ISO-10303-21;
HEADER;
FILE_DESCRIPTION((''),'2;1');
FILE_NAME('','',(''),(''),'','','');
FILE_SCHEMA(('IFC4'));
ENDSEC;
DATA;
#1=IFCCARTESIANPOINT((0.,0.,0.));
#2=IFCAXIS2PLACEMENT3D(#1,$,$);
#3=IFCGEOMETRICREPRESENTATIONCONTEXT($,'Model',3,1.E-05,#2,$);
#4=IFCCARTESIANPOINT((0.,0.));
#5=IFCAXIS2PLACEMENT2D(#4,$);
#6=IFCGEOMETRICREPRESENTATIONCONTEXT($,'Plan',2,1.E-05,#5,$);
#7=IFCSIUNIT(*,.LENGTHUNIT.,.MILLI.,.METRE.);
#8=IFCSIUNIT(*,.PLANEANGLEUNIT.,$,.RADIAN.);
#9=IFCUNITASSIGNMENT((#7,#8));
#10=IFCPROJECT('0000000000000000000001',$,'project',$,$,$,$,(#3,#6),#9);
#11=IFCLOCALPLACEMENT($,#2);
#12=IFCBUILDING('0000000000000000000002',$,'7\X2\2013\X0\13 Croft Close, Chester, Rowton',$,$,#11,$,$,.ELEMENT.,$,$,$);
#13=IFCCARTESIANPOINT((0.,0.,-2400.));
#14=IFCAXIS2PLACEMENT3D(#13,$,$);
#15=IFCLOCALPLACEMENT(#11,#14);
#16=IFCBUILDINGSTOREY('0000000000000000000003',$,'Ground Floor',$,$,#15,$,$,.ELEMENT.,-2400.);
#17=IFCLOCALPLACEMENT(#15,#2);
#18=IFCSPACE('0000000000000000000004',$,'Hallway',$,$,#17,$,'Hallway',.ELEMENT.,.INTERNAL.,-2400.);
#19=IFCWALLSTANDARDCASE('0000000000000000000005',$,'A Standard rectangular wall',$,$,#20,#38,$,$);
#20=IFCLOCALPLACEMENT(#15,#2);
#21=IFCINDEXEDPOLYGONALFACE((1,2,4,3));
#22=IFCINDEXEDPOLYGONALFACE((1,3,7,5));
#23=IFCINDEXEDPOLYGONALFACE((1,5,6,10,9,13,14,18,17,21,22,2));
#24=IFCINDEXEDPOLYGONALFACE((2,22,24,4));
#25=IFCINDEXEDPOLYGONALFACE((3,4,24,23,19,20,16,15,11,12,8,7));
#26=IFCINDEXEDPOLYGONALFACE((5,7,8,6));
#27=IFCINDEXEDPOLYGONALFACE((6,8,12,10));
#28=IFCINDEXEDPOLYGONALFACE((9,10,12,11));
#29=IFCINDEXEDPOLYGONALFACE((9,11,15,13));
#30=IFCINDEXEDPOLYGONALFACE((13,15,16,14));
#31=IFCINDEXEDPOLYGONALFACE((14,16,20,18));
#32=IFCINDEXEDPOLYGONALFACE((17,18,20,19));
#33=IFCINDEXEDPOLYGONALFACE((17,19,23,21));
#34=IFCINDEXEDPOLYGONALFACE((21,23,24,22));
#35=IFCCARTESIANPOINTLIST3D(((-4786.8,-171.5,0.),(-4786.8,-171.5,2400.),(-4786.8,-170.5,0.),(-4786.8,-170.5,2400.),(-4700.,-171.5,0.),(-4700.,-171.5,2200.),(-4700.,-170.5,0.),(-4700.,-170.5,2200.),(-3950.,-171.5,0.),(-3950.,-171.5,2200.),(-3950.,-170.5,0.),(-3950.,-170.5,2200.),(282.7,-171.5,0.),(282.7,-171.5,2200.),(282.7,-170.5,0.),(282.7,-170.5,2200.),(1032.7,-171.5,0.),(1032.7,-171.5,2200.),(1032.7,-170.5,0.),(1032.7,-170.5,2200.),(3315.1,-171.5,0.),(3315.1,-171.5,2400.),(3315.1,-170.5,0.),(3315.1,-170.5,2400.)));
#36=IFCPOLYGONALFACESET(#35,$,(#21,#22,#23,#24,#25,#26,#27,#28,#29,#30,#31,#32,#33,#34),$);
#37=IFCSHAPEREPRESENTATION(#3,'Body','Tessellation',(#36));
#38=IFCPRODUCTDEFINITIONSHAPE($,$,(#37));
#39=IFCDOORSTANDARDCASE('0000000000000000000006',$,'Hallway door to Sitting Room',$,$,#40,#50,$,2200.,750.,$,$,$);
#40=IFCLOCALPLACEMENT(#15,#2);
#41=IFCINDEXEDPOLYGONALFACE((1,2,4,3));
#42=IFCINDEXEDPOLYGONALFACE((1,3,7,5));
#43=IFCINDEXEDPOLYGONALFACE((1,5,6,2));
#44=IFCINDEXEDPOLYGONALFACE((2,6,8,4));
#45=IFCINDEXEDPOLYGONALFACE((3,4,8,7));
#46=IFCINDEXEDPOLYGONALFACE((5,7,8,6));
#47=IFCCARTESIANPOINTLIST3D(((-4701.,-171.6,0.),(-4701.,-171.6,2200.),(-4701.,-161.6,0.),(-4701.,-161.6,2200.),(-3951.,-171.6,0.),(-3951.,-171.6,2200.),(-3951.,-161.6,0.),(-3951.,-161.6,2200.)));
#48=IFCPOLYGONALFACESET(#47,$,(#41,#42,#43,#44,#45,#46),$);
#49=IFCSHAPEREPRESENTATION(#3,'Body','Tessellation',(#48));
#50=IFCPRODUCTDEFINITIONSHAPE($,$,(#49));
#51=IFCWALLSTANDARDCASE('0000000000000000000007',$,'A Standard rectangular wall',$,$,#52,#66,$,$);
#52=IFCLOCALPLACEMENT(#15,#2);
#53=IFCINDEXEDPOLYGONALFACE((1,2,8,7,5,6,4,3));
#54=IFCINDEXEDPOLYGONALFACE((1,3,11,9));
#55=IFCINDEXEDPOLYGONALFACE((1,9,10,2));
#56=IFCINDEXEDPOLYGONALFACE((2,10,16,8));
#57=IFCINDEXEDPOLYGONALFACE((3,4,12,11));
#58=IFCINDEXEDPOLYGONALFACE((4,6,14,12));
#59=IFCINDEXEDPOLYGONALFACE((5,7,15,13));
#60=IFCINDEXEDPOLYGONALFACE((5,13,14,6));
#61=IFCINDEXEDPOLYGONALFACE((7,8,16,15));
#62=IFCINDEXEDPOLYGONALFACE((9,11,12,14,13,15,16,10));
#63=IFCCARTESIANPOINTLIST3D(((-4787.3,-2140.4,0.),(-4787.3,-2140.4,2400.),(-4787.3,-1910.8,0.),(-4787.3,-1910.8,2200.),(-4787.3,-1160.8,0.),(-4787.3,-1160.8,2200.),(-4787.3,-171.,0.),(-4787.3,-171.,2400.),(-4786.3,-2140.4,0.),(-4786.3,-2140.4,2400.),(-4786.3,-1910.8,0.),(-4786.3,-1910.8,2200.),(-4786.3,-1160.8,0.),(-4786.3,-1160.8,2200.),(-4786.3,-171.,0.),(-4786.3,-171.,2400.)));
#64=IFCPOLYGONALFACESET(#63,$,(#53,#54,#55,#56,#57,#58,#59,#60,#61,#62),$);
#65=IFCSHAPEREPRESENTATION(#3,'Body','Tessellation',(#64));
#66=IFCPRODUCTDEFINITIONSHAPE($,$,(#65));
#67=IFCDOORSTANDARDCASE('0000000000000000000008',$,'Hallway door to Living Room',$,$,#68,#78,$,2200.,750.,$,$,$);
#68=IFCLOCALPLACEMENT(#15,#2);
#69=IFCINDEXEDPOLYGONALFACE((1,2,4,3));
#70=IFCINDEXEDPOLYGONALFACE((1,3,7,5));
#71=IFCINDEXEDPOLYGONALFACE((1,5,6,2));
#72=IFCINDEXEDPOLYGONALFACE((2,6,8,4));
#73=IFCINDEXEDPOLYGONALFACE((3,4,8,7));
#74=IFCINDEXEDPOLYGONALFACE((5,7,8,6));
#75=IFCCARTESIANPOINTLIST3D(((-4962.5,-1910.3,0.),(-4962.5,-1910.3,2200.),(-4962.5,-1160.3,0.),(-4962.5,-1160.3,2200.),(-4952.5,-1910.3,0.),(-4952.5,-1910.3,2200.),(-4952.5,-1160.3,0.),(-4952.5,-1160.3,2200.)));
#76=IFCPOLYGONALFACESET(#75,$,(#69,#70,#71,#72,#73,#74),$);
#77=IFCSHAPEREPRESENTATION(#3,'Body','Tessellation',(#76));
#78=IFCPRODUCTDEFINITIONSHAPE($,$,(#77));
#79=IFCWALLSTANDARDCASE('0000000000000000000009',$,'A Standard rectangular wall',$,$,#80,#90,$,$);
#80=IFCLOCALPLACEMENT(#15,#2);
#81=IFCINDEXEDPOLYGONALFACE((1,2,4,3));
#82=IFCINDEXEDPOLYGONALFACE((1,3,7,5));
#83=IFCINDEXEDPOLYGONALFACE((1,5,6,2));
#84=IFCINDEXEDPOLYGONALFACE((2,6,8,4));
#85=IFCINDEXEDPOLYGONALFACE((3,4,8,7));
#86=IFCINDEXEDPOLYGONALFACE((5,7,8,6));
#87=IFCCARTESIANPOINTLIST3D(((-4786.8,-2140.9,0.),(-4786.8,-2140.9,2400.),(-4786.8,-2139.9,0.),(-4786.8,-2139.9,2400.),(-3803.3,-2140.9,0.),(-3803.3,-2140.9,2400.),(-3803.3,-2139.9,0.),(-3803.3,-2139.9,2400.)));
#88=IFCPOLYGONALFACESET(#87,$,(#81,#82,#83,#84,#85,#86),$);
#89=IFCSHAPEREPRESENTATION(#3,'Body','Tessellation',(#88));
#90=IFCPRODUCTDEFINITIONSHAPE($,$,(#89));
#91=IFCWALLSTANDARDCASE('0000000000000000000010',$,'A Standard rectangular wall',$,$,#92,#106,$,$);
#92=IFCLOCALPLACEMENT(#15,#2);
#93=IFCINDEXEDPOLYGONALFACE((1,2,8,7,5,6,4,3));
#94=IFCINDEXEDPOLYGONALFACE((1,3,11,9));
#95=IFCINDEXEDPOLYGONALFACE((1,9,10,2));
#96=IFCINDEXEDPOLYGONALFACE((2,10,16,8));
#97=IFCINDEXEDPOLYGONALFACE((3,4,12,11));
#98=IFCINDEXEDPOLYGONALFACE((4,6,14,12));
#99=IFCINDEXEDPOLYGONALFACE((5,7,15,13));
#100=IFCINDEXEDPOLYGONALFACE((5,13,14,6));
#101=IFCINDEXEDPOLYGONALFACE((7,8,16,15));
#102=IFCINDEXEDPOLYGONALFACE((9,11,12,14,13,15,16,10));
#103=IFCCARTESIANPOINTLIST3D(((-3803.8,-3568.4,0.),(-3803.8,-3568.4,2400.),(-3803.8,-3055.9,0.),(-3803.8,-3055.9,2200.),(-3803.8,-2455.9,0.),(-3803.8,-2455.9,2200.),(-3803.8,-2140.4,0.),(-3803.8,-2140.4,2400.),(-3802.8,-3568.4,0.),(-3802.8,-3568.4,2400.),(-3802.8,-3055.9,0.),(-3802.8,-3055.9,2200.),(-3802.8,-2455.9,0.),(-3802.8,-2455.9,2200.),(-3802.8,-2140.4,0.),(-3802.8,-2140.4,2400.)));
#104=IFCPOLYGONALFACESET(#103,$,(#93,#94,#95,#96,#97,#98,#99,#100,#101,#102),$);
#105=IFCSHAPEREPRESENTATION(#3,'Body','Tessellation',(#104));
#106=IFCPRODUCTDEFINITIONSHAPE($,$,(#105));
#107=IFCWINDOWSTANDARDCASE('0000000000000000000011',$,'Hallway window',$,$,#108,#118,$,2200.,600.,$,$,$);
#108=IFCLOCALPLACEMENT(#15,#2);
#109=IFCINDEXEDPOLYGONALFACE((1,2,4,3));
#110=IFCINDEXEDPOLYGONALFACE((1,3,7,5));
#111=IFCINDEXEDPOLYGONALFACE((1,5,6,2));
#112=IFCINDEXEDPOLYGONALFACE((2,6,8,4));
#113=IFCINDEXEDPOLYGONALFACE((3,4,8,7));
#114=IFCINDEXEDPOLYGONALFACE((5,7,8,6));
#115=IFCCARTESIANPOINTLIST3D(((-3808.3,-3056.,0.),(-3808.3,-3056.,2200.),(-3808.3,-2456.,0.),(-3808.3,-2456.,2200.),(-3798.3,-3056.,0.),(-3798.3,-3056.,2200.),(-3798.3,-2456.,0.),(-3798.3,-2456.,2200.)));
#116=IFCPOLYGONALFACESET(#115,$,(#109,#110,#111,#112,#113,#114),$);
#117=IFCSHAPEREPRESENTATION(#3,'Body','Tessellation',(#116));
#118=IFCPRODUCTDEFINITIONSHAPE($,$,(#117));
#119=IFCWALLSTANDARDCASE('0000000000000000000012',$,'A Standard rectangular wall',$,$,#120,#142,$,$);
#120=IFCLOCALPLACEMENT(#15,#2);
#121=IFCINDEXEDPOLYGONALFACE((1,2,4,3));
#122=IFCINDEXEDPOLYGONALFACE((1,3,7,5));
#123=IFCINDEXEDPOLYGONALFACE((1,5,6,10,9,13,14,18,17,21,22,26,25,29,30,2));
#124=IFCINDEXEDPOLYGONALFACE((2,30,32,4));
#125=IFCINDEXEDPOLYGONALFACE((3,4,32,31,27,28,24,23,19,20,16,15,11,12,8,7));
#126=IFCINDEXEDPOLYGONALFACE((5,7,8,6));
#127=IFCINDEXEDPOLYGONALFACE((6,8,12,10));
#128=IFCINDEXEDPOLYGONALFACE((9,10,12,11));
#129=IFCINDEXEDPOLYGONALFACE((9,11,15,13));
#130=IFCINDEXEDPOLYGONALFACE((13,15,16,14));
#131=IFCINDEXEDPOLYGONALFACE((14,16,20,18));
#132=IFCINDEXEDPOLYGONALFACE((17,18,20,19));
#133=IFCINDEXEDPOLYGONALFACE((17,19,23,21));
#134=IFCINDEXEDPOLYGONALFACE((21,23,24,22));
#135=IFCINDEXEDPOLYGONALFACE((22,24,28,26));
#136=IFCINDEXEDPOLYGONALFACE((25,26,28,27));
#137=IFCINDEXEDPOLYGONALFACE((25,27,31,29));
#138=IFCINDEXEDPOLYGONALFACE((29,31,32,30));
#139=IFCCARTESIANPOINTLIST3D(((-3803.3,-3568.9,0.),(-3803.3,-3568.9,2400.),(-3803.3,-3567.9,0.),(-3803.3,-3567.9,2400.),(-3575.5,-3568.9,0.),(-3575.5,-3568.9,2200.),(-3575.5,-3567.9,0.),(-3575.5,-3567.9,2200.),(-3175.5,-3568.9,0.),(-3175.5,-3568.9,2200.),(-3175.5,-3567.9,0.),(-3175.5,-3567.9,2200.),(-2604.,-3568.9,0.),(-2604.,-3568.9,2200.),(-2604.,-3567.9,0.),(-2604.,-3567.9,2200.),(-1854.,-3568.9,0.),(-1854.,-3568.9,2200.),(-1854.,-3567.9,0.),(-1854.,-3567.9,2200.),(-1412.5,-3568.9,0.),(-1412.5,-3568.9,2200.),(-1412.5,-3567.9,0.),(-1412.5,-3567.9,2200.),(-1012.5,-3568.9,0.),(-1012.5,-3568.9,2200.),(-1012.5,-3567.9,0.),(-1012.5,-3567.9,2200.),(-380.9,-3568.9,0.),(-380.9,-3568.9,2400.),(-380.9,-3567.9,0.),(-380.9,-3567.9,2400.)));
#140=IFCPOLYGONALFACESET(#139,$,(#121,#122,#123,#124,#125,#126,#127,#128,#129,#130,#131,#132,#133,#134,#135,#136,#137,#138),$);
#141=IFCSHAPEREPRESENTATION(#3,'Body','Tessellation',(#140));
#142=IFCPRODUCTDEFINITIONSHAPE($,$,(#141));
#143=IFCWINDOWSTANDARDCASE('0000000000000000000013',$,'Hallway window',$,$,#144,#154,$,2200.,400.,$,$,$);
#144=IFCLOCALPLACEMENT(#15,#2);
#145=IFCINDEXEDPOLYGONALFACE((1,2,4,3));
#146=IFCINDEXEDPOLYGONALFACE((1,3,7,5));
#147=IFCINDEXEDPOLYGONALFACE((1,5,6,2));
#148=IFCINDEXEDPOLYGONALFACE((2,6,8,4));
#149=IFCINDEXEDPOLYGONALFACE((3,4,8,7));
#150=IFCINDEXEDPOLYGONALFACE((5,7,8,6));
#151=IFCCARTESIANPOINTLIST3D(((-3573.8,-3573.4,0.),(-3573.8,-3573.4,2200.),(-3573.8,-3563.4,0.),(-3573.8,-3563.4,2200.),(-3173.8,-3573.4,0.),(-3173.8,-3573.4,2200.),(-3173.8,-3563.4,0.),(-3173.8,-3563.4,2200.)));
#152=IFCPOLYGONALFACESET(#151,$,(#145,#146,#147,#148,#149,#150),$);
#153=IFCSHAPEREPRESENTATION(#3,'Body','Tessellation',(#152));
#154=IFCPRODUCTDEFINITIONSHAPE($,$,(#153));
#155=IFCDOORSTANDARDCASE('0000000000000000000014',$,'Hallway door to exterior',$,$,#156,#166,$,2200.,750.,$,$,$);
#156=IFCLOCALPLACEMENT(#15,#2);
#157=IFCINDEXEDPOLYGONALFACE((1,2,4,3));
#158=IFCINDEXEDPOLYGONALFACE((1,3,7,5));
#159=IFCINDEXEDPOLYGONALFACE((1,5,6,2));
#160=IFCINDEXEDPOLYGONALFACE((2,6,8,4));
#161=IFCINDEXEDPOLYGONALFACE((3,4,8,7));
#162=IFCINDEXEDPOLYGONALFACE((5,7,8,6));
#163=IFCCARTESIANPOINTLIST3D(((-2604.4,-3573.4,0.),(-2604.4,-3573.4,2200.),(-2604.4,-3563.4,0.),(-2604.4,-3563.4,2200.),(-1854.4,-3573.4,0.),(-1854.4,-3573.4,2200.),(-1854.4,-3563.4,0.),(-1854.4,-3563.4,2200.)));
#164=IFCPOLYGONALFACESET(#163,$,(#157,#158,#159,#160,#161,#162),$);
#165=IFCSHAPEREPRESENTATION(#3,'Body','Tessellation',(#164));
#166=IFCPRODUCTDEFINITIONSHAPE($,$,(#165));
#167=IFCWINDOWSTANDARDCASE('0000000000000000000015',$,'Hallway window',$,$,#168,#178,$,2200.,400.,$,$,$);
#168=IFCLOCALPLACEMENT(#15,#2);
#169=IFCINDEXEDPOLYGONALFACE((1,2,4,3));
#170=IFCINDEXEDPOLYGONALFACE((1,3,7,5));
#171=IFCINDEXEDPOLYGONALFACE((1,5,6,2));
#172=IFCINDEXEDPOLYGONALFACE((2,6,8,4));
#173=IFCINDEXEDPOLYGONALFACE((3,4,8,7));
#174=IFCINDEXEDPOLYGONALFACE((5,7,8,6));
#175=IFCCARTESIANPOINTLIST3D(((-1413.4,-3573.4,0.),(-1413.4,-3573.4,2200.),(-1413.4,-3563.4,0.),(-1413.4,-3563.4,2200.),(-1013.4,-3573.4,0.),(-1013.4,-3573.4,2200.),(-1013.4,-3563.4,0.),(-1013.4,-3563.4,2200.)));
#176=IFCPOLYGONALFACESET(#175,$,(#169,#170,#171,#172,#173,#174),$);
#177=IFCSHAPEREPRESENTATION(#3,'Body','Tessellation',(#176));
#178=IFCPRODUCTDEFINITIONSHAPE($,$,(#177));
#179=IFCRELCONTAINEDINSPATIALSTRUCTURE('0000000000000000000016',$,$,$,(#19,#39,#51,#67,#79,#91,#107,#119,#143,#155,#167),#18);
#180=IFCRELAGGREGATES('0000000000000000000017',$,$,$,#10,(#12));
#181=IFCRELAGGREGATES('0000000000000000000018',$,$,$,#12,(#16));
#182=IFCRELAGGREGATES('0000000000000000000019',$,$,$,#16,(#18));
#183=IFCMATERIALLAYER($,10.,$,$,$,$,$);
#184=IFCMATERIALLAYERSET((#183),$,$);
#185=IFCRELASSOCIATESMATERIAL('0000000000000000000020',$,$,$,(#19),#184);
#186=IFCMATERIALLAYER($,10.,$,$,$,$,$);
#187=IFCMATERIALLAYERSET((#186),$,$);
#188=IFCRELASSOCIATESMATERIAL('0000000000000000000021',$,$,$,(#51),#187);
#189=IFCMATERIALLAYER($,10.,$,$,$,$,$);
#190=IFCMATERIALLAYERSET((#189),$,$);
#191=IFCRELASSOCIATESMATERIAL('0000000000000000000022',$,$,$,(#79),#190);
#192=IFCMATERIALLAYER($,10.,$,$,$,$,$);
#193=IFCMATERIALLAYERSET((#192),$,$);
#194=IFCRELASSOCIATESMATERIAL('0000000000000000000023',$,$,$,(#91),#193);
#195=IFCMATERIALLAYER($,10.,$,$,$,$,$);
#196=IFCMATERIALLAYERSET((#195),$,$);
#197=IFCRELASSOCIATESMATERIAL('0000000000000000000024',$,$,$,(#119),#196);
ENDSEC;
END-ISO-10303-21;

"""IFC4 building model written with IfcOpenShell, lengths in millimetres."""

from ifc_helpers import new_model, si_unit, frame, origin, origin_2d, place, context, project, spatial, rectangle, extrude, layer, layer_set, layer_usage, element, fill, save


model = new_model("IFC4")

# Units and contexts
model_context = context("Model", 3, precision=1e-05, world=origin())
plan_context = context("Plan", 2, precision=1e-05, world=origin_2d())
ifc_project = project(units=[si_unit("LENGTHUNIT", "METRE", prefix="MILLI"), si_unit("PLANEANGLEUNIT", "RADIAN")], contexts=[model_context, plan_context])

# Building, storey
building_placement = place(None, origin())
building = spatial("IfcBuilding", under=ifc_project, at=building_placement, Name="7–13 Croft Close, Chester, Rowton", CompositionType="ELEMENT")
storey_placement = place(building_placement, frame((0.0, 0.0, -2400.0)))
storey = spatial("IfcBuildingStorey", under=building, at=storey_placement, Name="Ground Floor", CompositionType="ELEMENT", Elevation=-2400.0)

# Shared definitions
space_1_placement = place(storey_placement, origin())
space_1 = spatial("IfcSpace", under=storey, at=space_1_placement, Name="Hallway", LongName="Hallway", CompositionType="ELEMENT", PredefinedType="INTERNAL", ElevationWithFlooring=-2400.0)

# Wall, openings, door
ifc_layer_1 = layer(None, 10.0)
ifc_layer_set_1 = layer_set([ifc_layer_1])
ifc_layer_usage_1 = layer_usage(ifc_layer_set_1, "AXIS2", "NEGATIVE", 150.0)
wall_1_placement = place(storey_placement, origin())
wall_1 = element("IfcWallStandardCase", 1, at=wall_1_placement, inside=space_1, material=ifc_layer_usage_1, Name="A Standard rectangular wall", context=model_context, shape_type="SweptSolid", body=[
    extrude(rectangle(XDim=1.0, YDim=8101.9, at=origin_2d()), frame((-735.8, -171.0, 0.0), x_axis=(0.0, -1.0, 0.0)), (0.0, 0.0, 1.0), 2400.0),
])
opening_1_placement = place(storey_placement, origin())
element("IfcOpeningElement", 2, at=opening_1_placement, cuts=wall_1, context=model_context, shape_type="SweptSolid", body=[
    extrude(rectangle(XDim=10.0, YDim=750.0, at=origin_2d()), frame((657.7, -171.0, 0.0), x_axis=(0.0, 1.0, 0.0)), (0.0, 0.0, 1.0), 2200.0),
])
opening_2_placement = place(storey_placement, origin())
opening_2 = element("IfcOpeningElement", 3, at=opening_2_placement, cuts=wall_1, context=model_context, shape_type="SweptSolid", body=[
    extrude(rectangle(XDim=10.0, YDim=750.0, at=origin_2d()), frame((-4325.0, -171.0, 0.0), x_axis=(0.0, -1.0, 0.0)), (0.0, 0.0, 1.0), 2200.0),
])
door_1_placement = place(storey_placement, frame((-1.0, 4.4, 0.0)))
door_1 = element("IfcDoorStandardCase", 4, at=door_1_placement, inside=space_1, Name="Hallway door to Sitting Room", OverallHeight=2200.0, OverallWidth=750.0, context=model_context, shape_type="SweptSolid", body=[
    extrude(rectangle(XDim=10.0, YDim=750.0, at=origin_2d()), frame((-4325.0, -171.0, 0.0), x_axis=(0.0, -1.0, 0.0)), (0.0, 0.0, 1.0), 2200.0),
])
fill(opening_2, door_1)

# Wall, opening, door
ifc_layer_2 = layer(None, 10.0)
ifc_layer_set_2 = layer_set([ifc_layer_2])
ifc_layer_usage_2 = layer_usage(ifc_layer_set_2, "AXIS2", "NEGATIVE", 150.0)
wall_2_placement = place(storey_placement, origin())
wall_2 = element("IfcWallStandardCase", 5, at=wall_2_placement, inside=space_1, material=ifc_layer_usage_2, Name="A Standard rectangular wall", context=model_context, shape_type="SweptSolid", body=[
    extrude(rectangle(XDim=1.0, YDim=1969.4, at=origin_2d()), frame((-4786.8, -1155.7, 0.0), x_axis=(1.0, 0.0, 0.0)), (0.0, 0.0, 1.0), 2400.0),
])
opening_3_placement = place(storey_placement, origin())
opening_3 = element("IfcOpeningElement", 6, at=opening_3_placement, cuts=wall_2, context=model_context, shape_type="SweptSolid", body=[
    extrude(rectangle(XDim=10.0, YDim=750.0, at=origin_2d()), frame((-4786.8, -1535.8, 0.0), x_axis=(1.0, 0.0, 0.0)), (0.0, 0.0, 1.0), 2200.0),
])
door_2_placement = place(storey_placement, frame((-170.7, 0.5, 0.0)))
door_2 = element("IfcDoorStandardCase", 7, at=door_2_placement, inside=space_1, Name="Hallway door to Living Room", OverallHeight=2200.0, OverallWidth=750.0, context=model_context, shape_type="SweptSolid", body=[
    extrude(rectangle(XDim=10.0, YDim=750.0, at=origin_2d()), frame((-4786.8, -1535.8, 0.0), x_axis=(1.0, 0.0, 0.0)), (0.0, 0.0, 1.0), 2200.0),
])
fill(opening_3, door_2)

# Wall
ifc_layer_3 = layer(None, 10.0)
ifc_layer_set_3 = layer_set([ifc_layer_3])
ifc_layer_usage_3 = layer_usage(ifc_layer_set_3, "AXIS2", "NEGATIVE", 150.0)
wall_3_placement = place(storey_placement, origin())
element("IfcWallStandardCase", 8, at=wall_3_placement, inside=space_1, material=ifc_layer_usage_3, Name="A Standard rectangular wall", context=model_context, shape_type="SweptSolid", body=[
    extrude(rectangle(XDim=1.0, YDim=983.5, at=origin_2d()), frame((-4295.0, -2140.4, 0.0), x_axis=(0.0, 1.0, 0.0)), (0.0, 0.0, 1.0), 2400.0),
])

# Wall, opening, window
ifc_layer_4 = layer(None, 10.0)
ifc_layer_set_4 = layer_set([ifc_layer_4])
ifc_layer_usage_4 = layer_usage(ifc_layer_set_4, "AXIS2", "NEGATIVE", 150.0)
wall_4_placement = place(storey_placement, origin())
wall_4 = element("IfcWallStandardCase", 9, at=wall_4_placement, inside=space_1, material=ifc_layer_usage_4, Name="A Standard rectangular wall", context=model_context, shape_type="SweptSolid", body=[
    extrude(rectangle(XDim=1.0, YDim=1428.0, at=origin_2d()), frame((-3803.3, -2854.4, 0.0), x_axis=(1.0, 0.0, 0.0)), (0.0, 0.0, 1.0), 2400.0),
])
opening_4_placement = place(storey_placement, origin())
opening_4 = element("IfcOpeningElement", 10, at=opening_4_placement, cuts=wall_4, context=model_context, shape_type="SweptSolid", body=[
    extrude(rectangle(XDim=10.0, YDim=600.0, at=origin_2d()), frame((-3803.3, -2755.9, 0.0), x_axis=(1.0, 0.0, 0.0)), (0.0, 0.0, 1.0), 2200.0),
])
window_1_placement = place(storey_placement, frame((0.0, -0.1, 0.0)))
window_1 = element("IfcWindowStandardCase", 11, at=window_1_placement, inside=space_1, Name="Hallway window", OverallHeight=2200.0, OverallWidth=600.0, context=model_context, shape_type="SweptSolid", body=[
    extrude(rectangle(XDim=10.0, YDim=600.0, at=origin_2d()), frame((-3803.3, -2755.9, 0.0), x_axis=(1.0, 0.0, 0.0)), (0.0, 0.0, 1.0), 2200.0),
])
fill(opening_4, window_1)

# Wall, openings, windows, door
ifc_layer_5 = layer(None, 10.0)
ifc_layer_set_5 = layer_set([ifc_layer_5])
ifc_layer_usage_5 = layer_usage(ifc_layer_set_5, "AXIS2", "NEGATIVE", 150.0)
wall_5_placement = place(storey_placement, origin())
wall_5 = element("IfcWallStandardCase", 12, at=wall_5_placement, inside=space_1, material=ifc_layer_usage_5, Name="A Standard rectangular wall", context=model_context, shape_type="SweptSolid", body=[
    extrude(rectangle(XDim=1.0, YDim=3422.4, at=origin_2d()), frame((-2092.1, -3568.4, 0.0), x_axis=(0.0, 1.0, 0.0)), (0.0, 0.0, 1.0), 2400.0),
])
opening_5_placement = place(storey_placement, origin())
opening_5 = element("IfcOpeningElement", 13, at=opening_5_placement, cuts=wall_5, context=model_context, shape_type="SweptSolid", body=[
    extrude(rectangle(XDim=10.0, YDim=400.0, at=origin_2d()), frame((-3375.5, -3568.4, 0.0), x_axis=(0.0, 1.0, 0.0)), (0.0, 0.0, 1.0), 2200.0),
])
opening_6_placement = place(storey_placement, origin())
opening_6 = element("IfcOpeningElement", 14, at=opening_6_placement, cuts=wall_5, context=model_context, shape_type="SweptSolid", body=[
    extrude(rectangle(XDim=10.0, YDim=750.0, at=origin_2d()), frame((-2229.0, -3568.4, 0.0), x_axis=(0.0, 1.0, 0.0)), (0.0, 0.0, 1.0), 2200.0),
])
opening_7_placement = place(storey_placement, origin())
opening_7 = element("IfcOpeningElement", 15, at=opening_7_placement, cuts=wall_5, context=model_context, shape_type="SweptSolid", body=[
    extrude(rectangle(XDim=10.0, YDim=400.0, at=origin_2d()), frame((-1212.5, -3568.4, 0.0), x_axis=(0.0, 1.0, 0.0)), (0.0, 0.0, 1.0), 2200.0),
])
window_2_placement = place(storey_placement, frame((1.7, 0.0, 0.0)))
window_2 = element("IfcWindowStandardCase", 16, at=window_2_placement, inside=space_1, Name="Hallway window", OverallHeight=2200.0, OverallWidth=400.0, context=model_context, shape_type="SweptSolid", body=[
    extrude(rectangle(XDim=10.0, YDim=400.0, at=origin_2d()), frame((-3375.5, -3568.4, 0.0), x_axis=(0.0, 1.0, 0.0)), (0.0, 0.0, 1.0), 2200.0),
])
fill(opening_5, window_2)
door_3_placement = place(storey_placement, frame((-0.4, 0.0, 0.0)))
door_3 = element("IfcDoorStandardCase", 17, at=door_3_placement, inside=space_1, Name="Hallway door to exterior", OverallHeight=2200.0, OverallWidth=750.0, context=model_context, shape_type="SweptSolid", body=[
    extrude(rectangle(XDim=10.0, YDim=750.0, at=origin_2d()), frame((-2229.0, -3568.4, 0.0), x_axis=(0.0, 1.0, 0.0)), (0.0, 0.0, 1.0), 2200.0),
])
fill(opening_6, door_3)
window_3_placement = place(storey_placement, frame((-0.9, 0.0, 0.0)))
window_3 = element("IfcWindowStandardCase", 18, at=window_3_placement, inside=space_1, Name="Hallway window", OverallHeight=2200.0, OverallWidth=400.0, context=model_context, shape_type="SweptSolid", body=[
    extrude(rectangle(XDim=10.0, YDim=400.0, at=origin_2d()), frame((-1212.5, -3568.4, 0.0), x_axis=(0.0, 1.0, 0.0)), (0.0, 0.0, 1.0), 2200.0),
])
fill(opening_7, window_3)

save(model, "model.ifc")
